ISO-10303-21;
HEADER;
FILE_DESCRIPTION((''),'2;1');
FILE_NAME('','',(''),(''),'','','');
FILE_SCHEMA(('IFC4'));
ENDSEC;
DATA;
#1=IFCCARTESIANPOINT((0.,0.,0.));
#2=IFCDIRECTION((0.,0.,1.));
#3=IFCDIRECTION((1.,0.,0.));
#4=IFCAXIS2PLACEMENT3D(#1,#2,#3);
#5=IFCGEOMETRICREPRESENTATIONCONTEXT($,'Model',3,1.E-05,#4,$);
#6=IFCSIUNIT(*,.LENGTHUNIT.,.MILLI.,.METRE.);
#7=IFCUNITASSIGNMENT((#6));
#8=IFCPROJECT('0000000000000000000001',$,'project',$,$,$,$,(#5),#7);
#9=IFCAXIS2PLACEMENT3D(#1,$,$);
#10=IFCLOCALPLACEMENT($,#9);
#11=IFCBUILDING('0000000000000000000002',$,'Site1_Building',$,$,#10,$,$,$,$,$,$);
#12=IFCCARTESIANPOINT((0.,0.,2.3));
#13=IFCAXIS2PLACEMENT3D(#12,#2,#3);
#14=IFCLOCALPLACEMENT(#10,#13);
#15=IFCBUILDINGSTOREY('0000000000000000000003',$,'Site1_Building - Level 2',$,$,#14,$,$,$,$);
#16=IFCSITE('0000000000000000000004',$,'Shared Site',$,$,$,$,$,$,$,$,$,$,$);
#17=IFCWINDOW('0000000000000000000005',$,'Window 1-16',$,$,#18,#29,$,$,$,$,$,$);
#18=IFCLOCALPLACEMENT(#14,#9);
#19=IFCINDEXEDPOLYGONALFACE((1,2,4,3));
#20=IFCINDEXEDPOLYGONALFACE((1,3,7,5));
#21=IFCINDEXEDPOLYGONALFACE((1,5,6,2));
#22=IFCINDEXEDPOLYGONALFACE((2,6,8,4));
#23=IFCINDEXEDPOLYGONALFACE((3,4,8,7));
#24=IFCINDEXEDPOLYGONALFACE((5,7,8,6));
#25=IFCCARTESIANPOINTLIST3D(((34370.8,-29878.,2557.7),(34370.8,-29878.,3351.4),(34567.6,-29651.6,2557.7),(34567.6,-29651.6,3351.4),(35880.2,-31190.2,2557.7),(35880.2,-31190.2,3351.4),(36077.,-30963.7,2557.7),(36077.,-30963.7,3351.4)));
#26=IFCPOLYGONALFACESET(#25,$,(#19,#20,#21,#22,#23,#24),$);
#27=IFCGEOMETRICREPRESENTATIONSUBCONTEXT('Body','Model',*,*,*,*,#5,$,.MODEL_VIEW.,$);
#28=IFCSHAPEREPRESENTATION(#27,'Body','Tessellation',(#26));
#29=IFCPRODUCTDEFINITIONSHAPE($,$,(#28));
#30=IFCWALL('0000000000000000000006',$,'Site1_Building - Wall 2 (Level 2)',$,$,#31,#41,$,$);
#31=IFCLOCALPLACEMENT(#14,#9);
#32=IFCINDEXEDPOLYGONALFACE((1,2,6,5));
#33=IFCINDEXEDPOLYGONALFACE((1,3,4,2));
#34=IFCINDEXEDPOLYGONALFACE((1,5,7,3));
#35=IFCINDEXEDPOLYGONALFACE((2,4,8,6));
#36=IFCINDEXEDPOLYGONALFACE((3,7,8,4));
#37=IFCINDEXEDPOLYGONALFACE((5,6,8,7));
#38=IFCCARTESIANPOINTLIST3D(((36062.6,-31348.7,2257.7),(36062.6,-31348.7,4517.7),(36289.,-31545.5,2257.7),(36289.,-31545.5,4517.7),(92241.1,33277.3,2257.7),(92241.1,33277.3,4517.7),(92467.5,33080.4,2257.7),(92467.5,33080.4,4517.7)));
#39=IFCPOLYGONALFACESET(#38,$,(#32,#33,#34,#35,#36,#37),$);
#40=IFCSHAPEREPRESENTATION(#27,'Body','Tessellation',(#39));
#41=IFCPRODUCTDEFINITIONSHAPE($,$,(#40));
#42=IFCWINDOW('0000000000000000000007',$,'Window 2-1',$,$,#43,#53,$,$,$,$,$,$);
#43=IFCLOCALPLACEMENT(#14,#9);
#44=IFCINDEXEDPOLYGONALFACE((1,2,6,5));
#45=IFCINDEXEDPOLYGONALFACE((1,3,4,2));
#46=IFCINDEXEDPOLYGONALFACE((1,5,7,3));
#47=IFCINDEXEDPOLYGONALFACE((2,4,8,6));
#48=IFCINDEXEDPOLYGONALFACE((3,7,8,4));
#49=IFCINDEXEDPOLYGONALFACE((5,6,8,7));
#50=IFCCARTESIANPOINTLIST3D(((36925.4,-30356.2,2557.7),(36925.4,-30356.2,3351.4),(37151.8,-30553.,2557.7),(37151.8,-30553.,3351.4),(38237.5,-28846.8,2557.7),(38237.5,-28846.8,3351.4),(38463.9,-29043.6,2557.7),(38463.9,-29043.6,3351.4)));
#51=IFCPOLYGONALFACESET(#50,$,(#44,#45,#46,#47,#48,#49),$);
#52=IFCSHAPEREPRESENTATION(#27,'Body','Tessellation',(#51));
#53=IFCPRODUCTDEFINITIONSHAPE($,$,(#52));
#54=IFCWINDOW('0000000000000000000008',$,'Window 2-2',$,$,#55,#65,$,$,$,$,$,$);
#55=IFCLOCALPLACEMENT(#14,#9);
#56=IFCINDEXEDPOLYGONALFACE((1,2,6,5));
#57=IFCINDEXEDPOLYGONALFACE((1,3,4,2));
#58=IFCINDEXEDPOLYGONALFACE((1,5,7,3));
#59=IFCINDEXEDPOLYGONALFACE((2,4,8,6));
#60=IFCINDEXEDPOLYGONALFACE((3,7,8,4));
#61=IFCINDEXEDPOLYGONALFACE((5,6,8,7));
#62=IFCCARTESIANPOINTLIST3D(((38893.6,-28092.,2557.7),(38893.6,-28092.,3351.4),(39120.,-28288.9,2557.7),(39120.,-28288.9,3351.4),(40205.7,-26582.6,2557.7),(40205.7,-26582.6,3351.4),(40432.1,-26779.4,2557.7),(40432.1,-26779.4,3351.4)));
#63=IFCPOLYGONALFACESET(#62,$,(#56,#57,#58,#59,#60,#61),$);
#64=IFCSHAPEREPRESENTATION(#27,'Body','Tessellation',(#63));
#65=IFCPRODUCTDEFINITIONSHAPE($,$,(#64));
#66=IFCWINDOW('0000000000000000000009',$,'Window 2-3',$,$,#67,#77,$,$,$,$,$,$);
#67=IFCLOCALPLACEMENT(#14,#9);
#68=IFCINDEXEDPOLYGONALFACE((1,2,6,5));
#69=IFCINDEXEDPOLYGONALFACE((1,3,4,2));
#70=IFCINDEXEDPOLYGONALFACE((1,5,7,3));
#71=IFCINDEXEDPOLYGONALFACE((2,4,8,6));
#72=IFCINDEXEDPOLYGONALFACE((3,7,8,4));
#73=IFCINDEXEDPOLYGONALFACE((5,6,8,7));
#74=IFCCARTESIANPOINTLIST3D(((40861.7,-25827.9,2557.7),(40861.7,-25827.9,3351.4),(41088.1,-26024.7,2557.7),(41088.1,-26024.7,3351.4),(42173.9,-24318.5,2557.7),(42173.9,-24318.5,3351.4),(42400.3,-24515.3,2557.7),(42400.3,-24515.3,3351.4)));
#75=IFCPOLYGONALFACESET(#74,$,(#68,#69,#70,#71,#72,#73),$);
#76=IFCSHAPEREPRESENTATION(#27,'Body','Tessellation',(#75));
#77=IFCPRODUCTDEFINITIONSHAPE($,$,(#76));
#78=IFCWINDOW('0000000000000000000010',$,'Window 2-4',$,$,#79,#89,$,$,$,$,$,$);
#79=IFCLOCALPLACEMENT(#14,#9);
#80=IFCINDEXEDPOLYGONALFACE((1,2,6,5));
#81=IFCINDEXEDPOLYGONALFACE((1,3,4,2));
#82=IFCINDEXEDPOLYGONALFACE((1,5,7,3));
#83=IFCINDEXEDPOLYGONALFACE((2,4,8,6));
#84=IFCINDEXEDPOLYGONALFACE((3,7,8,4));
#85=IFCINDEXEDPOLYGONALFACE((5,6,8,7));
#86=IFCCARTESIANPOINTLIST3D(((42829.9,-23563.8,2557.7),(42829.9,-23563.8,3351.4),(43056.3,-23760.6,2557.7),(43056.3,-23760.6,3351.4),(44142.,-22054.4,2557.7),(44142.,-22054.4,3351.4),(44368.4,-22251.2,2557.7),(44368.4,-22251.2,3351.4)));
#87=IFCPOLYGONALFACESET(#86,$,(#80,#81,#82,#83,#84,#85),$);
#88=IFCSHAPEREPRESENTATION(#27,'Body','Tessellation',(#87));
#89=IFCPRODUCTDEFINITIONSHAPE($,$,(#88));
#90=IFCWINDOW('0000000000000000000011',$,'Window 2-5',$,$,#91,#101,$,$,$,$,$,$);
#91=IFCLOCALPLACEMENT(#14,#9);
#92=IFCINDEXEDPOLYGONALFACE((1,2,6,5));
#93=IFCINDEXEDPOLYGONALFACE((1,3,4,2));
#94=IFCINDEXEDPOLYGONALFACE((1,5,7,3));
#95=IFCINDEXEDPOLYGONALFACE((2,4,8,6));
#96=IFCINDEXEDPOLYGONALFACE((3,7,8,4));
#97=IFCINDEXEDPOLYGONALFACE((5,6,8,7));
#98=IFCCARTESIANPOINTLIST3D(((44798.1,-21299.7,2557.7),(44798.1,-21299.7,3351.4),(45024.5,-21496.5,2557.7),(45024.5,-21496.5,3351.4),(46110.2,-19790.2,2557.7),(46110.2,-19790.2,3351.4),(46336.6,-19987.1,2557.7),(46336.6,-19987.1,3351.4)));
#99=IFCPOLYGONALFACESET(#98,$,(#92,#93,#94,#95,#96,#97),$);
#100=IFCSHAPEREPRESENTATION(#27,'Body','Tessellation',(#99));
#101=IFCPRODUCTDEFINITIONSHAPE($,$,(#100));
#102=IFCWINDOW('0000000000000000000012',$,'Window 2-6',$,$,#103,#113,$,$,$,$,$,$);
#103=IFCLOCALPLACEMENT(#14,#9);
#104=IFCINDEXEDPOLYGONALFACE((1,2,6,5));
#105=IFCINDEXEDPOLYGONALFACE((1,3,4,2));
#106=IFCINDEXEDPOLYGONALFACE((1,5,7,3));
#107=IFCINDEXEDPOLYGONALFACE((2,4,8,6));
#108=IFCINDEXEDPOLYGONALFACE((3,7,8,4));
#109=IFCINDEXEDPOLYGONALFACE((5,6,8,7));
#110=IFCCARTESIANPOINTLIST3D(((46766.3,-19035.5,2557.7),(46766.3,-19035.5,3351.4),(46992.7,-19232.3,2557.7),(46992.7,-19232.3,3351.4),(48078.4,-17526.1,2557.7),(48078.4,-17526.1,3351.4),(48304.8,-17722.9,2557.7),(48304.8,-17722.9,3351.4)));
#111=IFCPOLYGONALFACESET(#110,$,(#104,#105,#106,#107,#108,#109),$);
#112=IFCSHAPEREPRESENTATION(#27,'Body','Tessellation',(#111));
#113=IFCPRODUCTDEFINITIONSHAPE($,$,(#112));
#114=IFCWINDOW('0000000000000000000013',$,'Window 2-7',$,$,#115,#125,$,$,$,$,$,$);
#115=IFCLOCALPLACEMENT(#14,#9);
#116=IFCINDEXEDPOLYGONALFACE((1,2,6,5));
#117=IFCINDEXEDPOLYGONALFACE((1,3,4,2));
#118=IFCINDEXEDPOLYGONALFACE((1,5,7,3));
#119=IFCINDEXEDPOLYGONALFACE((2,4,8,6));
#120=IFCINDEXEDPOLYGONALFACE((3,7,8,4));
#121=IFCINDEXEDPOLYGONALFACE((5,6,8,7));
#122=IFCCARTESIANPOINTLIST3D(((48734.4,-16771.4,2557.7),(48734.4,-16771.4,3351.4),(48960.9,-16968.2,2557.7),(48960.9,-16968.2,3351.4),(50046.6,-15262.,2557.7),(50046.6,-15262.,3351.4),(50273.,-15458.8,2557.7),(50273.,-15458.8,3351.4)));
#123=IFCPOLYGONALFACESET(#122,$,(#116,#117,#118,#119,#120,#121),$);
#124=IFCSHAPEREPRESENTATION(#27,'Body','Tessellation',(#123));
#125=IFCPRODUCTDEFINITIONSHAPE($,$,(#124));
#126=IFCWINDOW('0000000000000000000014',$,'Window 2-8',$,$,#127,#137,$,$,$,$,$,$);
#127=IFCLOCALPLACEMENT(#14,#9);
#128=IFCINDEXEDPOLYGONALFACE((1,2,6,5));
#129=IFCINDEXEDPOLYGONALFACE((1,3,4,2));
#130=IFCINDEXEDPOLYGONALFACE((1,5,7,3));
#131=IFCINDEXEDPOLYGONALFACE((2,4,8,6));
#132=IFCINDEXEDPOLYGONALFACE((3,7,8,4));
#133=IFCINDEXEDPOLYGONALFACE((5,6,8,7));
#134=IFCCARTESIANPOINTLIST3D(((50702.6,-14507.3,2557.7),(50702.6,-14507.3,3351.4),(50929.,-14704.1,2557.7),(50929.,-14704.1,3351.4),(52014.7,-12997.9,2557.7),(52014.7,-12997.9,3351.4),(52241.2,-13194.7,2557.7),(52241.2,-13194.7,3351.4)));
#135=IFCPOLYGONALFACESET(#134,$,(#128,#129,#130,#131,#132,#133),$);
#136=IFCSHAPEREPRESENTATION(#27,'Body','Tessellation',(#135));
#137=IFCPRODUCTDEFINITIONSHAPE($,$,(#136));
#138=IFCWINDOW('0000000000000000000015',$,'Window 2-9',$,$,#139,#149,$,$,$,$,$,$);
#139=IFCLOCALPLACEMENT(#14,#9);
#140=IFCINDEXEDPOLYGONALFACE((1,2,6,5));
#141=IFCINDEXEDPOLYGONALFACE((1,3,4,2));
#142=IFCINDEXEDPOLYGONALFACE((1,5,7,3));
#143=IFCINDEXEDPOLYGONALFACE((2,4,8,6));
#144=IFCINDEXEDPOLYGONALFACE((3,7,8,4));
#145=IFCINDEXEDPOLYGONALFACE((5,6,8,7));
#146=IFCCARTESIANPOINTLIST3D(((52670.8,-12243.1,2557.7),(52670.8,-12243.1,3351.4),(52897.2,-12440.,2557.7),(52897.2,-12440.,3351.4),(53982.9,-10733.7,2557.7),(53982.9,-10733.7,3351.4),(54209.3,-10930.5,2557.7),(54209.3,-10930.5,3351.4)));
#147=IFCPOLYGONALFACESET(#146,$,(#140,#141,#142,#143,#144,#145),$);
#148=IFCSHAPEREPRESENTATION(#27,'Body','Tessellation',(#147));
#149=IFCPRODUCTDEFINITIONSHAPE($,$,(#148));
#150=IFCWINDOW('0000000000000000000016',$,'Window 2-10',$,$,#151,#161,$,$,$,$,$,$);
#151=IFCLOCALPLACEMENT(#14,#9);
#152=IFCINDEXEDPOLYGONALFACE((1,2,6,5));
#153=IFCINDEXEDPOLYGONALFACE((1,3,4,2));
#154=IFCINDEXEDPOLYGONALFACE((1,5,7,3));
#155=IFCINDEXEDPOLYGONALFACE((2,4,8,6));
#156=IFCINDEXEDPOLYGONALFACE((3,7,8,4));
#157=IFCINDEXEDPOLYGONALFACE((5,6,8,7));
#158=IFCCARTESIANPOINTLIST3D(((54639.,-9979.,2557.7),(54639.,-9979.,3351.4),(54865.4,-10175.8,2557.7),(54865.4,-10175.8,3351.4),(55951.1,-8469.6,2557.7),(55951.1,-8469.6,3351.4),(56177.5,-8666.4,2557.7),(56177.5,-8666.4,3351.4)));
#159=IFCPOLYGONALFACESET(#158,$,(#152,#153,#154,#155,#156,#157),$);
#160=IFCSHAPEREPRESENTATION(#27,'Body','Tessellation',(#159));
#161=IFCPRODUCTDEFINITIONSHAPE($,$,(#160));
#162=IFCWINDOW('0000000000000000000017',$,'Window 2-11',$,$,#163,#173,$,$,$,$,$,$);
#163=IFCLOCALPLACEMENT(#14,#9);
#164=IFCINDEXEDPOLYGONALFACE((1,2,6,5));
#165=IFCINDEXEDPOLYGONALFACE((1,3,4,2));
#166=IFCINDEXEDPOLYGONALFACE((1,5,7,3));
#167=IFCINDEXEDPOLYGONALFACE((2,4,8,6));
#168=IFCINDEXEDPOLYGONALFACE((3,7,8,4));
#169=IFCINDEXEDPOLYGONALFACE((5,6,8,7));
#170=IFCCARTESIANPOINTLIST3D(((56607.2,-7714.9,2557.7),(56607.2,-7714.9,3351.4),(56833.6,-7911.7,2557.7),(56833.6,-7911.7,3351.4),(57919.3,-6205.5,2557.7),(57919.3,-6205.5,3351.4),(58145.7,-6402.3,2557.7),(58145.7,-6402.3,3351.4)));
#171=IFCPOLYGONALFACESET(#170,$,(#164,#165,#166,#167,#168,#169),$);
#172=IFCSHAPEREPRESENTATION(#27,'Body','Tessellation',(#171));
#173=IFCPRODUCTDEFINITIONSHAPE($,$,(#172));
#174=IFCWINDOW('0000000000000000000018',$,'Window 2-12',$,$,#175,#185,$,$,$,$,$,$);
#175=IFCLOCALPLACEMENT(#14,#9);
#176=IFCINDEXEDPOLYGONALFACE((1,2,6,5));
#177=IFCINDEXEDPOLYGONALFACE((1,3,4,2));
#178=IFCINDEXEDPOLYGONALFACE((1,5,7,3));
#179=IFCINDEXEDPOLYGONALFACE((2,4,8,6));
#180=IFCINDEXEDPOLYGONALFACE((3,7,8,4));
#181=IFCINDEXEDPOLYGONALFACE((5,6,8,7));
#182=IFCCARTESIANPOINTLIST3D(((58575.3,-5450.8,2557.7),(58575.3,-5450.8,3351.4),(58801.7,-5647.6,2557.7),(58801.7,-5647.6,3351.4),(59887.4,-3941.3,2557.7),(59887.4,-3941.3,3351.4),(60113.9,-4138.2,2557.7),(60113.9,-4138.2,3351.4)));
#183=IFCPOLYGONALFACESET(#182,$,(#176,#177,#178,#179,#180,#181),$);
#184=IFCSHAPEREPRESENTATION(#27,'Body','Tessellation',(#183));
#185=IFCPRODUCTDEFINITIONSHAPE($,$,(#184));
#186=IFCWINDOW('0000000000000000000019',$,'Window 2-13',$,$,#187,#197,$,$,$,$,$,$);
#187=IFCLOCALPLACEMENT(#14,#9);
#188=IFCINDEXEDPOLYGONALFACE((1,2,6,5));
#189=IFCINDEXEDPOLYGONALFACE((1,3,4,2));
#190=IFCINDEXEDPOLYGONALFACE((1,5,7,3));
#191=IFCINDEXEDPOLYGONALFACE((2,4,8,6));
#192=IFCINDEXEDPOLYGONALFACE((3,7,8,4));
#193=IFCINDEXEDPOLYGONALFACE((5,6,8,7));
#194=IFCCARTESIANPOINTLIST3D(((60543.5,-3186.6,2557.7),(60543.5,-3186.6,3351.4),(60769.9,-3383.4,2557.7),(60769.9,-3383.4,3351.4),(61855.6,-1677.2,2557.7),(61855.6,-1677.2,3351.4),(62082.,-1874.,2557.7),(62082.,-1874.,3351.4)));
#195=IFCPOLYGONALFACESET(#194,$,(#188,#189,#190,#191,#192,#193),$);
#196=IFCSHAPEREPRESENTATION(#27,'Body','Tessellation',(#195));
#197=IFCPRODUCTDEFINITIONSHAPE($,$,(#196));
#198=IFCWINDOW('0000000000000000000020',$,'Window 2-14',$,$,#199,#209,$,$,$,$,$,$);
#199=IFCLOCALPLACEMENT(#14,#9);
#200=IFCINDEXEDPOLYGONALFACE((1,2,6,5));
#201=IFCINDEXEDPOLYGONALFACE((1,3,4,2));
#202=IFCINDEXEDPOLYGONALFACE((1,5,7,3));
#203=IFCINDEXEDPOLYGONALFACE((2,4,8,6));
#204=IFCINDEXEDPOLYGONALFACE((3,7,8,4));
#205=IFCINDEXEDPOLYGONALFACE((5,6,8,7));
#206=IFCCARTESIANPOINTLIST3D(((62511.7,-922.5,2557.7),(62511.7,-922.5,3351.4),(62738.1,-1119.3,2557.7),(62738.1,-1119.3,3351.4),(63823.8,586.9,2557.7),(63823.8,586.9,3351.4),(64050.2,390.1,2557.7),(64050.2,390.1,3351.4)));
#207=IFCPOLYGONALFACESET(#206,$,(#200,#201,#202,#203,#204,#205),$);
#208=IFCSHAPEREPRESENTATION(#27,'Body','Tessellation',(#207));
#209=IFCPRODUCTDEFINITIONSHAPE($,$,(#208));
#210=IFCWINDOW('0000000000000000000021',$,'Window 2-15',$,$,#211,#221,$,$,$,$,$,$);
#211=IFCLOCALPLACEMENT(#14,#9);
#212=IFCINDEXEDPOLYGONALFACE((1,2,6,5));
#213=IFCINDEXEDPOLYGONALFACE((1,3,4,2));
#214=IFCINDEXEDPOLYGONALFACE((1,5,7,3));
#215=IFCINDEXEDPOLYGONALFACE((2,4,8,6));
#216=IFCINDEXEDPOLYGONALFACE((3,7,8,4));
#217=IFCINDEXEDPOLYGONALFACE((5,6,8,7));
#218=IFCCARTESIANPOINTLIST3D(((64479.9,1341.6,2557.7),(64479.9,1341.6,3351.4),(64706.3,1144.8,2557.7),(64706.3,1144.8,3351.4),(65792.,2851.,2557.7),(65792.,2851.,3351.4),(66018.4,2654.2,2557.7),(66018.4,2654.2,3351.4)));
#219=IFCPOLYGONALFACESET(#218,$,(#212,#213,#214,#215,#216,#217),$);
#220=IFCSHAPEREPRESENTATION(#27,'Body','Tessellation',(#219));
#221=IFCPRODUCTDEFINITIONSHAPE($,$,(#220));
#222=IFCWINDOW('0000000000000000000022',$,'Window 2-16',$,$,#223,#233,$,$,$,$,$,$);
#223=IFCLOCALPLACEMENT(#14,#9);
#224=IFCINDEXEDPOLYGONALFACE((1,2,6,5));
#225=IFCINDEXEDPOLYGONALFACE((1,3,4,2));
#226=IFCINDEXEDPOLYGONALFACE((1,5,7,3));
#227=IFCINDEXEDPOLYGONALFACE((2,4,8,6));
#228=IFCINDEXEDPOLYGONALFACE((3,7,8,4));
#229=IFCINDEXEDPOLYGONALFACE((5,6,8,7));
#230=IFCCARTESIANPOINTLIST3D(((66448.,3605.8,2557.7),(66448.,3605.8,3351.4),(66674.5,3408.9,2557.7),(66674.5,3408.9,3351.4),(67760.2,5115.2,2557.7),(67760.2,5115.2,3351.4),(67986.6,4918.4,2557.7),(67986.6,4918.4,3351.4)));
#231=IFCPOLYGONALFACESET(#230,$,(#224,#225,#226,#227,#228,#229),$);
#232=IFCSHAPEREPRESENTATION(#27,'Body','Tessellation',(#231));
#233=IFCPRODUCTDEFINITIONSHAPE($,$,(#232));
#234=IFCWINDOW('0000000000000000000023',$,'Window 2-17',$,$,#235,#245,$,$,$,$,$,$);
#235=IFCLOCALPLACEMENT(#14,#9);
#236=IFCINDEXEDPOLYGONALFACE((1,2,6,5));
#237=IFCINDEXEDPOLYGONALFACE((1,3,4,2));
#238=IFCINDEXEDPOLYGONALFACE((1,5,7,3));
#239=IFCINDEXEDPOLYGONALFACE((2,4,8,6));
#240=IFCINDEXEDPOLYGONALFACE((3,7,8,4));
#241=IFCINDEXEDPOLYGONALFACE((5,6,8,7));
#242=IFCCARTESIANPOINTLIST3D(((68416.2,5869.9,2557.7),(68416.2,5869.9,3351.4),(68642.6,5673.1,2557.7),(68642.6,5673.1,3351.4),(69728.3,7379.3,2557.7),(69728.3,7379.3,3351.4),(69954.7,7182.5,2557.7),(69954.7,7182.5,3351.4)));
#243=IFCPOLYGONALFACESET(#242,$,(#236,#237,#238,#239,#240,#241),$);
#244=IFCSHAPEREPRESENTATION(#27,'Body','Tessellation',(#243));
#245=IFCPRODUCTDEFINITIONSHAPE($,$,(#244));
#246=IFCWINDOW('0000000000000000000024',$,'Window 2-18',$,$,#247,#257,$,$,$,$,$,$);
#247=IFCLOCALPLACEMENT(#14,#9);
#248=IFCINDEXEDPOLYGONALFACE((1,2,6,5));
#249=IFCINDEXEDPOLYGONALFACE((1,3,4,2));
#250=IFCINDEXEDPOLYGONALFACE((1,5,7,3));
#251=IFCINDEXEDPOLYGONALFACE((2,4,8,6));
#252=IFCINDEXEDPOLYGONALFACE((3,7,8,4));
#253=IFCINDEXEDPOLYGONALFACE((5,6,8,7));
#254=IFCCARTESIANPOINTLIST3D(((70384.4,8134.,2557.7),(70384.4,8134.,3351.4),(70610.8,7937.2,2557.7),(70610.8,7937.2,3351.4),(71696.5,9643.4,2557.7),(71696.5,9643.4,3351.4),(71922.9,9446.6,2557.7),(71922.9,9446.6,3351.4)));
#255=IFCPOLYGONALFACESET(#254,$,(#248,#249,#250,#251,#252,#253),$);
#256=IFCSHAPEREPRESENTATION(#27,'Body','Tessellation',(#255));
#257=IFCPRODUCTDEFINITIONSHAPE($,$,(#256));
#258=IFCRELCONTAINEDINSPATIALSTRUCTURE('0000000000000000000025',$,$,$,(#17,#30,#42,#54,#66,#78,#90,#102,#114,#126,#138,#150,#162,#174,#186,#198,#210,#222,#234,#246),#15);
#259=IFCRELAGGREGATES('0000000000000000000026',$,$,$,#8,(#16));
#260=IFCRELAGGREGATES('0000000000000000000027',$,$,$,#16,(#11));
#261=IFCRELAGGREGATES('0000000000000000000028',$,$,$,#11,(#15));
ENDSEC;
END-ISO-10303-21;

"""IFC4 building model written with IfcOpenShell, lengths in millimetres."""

from ifc_helpers import new_model, si_unit, frame, origin, origin_with_axes, place, context, subcontext, project, spatial, indexed_curve, outline, extrude, element, save


model = new_model("IFC4")

# Units and contexts
model_context = context("Model", 3, precision=1e-05, world=origin_with_axes())
body_context = subcontext(model_context, "Body", "Model", "MODEL_VIEW")
ifc_project = project(units=[si_unit("LENGTHUNIT", "METRE", prefix="MILLI")], contexts=[model_context])

# Site, building, storey
site = spatial("IfcSite", under=ifc_project, Name="Shared Site")
building_placement = place(None, origin())
building = spatial("IfcBuilding", under=site, at=building_placement, Name="Site1_Building")
storey_placement = place(building_placement, frame((0.0, 0.0, 2.3), z_axis=(0.0, 0.0, 1.0), x_axis=(1.0, 0.0, 0.0)))
storey = spatial("IfcBuildingStorey", under=building, at=storey_placement, Name="Site1_Building - Level 2")

# Window
window_placement = place(storey_placement, frame((34370.8, -29878.0, 2557.7), z_axis=(0.0, 0.0, 1.0), x_axis=(0.75471, -0.656059, 0.0)))
element("IfcWindow", 1, at=window_placement, inside=storey, Name="Window 1-16", context=body_context, shape_type="SweptSolid", body=[
    extrude(outline(indexed_curve([(0.0, 0.0), (0.0, 300.0), (2000.0, 300.0), (2000.0, 0.0), (0.0, 0.0)], self_intersect=False)), origin_with_axes(), (0.0, 0.0, 1.0), 793.6),
])

# Wall
wall_placement = place(storey_placement, frame((36289.0, -31545.5, 2257.7), z_axis=(0.0, 0.0, 1.0), x_axis=(0.656059, 0.75471, 0.0)))
element("IfcWall", 2, at=wall_placement, inside=storey, Name="Site1_Building - Wall 2 (Level 2)", context=body_context, shape_type="SweptSolid", body=[
    extrude(outline(indexed_curve([(0.0, 0.0), (0.0, 300.0), (85630.3, 300.0), (85630.3, 0.0), (0.0, 0.0)], self_intersect=False)), origin_with_axes(), (0.0, 0.0, 1.0), 2260.0),
])

# Windows
for number, where, z_axis, x_axis, name in (
    (3, (37151.8, -30553.0, 2557.7), (0.0, 0.0, 1.0), (0.656059, 0.75471, 0.0), "Window 2-1"),
    (4, (39120.0, -28288.9, 2557.7), (0.0, 0.0, 1.0), (0.656059, 0.75471, 0.0), "Window 2-2"),
    (5, (41088.1, -26024.7, 2557.7), (0.0, 0.0, 1.0), (0.656059, 0.75471, 0.0), "Window 2-3"),
    (6, (43056.3, -23760.6, 2557.7), (0.0, 0.0, 1.0), (0.656059, 0.75471, 0.0), "Window 2-4"),
    (7, (45024.5, -21496.5, 2557.7), (0.0, 0.0, 1.0), (0.656059, 0.75471, 0.0), "Window 2-5"),
    (8, (46992.7, -19232.3, 2557.7), (0.0, 0.0, 1.0), (0.656059, 0.75471, 0.0), "Window 2-6"),
    (9, (48960.9, -16968.2, 2557.7), (0.0, 0.0, 1.0), (0.656059, 0.75471, 0.0), "Window 2-7"),
    (10, (50929.0, -14704.1, 2557.7), (0.0, 0.0, 1.0), (0.656059, 0.75471, 0.0), "Window 2-8"),
    (11, (52897.2, -12440.0, 2557.7), (0.0, 0.0, 1.0), (0.656059, 0.75471, 0.0), "Window 2-9"),
    (12, (54865.4, -10175.8, 2557.7), (0.0, 0.0, 1.0), (0.656059, 0.75471, 0.0), "Window 2-10"),
    (13, (56833.6, -7911.7, 2557.7), (0.0, 0.0, 1.0), (0.656059, 0.75471, 0.0), "Window 2-11"),
    (14, (58801.7, -5647.6, 2557.7), (0.0, 0.0, 1.0), (0.656059, 0.75471, 0.0), "Window 2-12"),
    (15, (60769.9, -3383.4, 2557.7), (0.0, 0.0, 1.0), (0.656059, 0.75471, 0.0), "Window 2-13"),
    (16, (62738.1, -1119.3, 2557.7), (0.0, 0.0, 1.0), (0.656059, 0.75471, 0.0), "Window 2-14"),
    (17, (64706.3, 1144.8, 2557.7), (0.0, 0.0, 1.0), (0.656059, 0.75471, 0.0), "Window 2-15"),
    (18, (66674.5, 3408.9, 2557.7), (0.0, 0.0, 1.0), (0.656059, 0.75471, 0.0), "Window 2-16"),
    (19, (68642.6, 5673.1, 2557.7), (0.0, 0.0, 1.0), (0.656059, 0.75471, 0.0), "Window 2-17"),
    (20, (70610.8, 7937.2, 2557.7), (0.0, 0.0, 1.0), (0.656059, 0.75471, 0.0), "Window 2-18"),
):
    element("IfcWindow", number, at=place(storey_placement, frame(where, z_axis=z_axis, x_axis=x_axis)), inside=storey, Name=name, context=body_context, shape_type="SweptSolid", body=[
        extrude(outline(indexed_curve([(0.0, 0.0), (0.0, 300.0), (2000.0, 300.0), (2000.0, 0.0), (0.0, 0.0)], self_intersect=False)), origin_with_axes(), (0.0, 0.0, 1.0), 793.6),
    ])

save(model, "model.ifc")
